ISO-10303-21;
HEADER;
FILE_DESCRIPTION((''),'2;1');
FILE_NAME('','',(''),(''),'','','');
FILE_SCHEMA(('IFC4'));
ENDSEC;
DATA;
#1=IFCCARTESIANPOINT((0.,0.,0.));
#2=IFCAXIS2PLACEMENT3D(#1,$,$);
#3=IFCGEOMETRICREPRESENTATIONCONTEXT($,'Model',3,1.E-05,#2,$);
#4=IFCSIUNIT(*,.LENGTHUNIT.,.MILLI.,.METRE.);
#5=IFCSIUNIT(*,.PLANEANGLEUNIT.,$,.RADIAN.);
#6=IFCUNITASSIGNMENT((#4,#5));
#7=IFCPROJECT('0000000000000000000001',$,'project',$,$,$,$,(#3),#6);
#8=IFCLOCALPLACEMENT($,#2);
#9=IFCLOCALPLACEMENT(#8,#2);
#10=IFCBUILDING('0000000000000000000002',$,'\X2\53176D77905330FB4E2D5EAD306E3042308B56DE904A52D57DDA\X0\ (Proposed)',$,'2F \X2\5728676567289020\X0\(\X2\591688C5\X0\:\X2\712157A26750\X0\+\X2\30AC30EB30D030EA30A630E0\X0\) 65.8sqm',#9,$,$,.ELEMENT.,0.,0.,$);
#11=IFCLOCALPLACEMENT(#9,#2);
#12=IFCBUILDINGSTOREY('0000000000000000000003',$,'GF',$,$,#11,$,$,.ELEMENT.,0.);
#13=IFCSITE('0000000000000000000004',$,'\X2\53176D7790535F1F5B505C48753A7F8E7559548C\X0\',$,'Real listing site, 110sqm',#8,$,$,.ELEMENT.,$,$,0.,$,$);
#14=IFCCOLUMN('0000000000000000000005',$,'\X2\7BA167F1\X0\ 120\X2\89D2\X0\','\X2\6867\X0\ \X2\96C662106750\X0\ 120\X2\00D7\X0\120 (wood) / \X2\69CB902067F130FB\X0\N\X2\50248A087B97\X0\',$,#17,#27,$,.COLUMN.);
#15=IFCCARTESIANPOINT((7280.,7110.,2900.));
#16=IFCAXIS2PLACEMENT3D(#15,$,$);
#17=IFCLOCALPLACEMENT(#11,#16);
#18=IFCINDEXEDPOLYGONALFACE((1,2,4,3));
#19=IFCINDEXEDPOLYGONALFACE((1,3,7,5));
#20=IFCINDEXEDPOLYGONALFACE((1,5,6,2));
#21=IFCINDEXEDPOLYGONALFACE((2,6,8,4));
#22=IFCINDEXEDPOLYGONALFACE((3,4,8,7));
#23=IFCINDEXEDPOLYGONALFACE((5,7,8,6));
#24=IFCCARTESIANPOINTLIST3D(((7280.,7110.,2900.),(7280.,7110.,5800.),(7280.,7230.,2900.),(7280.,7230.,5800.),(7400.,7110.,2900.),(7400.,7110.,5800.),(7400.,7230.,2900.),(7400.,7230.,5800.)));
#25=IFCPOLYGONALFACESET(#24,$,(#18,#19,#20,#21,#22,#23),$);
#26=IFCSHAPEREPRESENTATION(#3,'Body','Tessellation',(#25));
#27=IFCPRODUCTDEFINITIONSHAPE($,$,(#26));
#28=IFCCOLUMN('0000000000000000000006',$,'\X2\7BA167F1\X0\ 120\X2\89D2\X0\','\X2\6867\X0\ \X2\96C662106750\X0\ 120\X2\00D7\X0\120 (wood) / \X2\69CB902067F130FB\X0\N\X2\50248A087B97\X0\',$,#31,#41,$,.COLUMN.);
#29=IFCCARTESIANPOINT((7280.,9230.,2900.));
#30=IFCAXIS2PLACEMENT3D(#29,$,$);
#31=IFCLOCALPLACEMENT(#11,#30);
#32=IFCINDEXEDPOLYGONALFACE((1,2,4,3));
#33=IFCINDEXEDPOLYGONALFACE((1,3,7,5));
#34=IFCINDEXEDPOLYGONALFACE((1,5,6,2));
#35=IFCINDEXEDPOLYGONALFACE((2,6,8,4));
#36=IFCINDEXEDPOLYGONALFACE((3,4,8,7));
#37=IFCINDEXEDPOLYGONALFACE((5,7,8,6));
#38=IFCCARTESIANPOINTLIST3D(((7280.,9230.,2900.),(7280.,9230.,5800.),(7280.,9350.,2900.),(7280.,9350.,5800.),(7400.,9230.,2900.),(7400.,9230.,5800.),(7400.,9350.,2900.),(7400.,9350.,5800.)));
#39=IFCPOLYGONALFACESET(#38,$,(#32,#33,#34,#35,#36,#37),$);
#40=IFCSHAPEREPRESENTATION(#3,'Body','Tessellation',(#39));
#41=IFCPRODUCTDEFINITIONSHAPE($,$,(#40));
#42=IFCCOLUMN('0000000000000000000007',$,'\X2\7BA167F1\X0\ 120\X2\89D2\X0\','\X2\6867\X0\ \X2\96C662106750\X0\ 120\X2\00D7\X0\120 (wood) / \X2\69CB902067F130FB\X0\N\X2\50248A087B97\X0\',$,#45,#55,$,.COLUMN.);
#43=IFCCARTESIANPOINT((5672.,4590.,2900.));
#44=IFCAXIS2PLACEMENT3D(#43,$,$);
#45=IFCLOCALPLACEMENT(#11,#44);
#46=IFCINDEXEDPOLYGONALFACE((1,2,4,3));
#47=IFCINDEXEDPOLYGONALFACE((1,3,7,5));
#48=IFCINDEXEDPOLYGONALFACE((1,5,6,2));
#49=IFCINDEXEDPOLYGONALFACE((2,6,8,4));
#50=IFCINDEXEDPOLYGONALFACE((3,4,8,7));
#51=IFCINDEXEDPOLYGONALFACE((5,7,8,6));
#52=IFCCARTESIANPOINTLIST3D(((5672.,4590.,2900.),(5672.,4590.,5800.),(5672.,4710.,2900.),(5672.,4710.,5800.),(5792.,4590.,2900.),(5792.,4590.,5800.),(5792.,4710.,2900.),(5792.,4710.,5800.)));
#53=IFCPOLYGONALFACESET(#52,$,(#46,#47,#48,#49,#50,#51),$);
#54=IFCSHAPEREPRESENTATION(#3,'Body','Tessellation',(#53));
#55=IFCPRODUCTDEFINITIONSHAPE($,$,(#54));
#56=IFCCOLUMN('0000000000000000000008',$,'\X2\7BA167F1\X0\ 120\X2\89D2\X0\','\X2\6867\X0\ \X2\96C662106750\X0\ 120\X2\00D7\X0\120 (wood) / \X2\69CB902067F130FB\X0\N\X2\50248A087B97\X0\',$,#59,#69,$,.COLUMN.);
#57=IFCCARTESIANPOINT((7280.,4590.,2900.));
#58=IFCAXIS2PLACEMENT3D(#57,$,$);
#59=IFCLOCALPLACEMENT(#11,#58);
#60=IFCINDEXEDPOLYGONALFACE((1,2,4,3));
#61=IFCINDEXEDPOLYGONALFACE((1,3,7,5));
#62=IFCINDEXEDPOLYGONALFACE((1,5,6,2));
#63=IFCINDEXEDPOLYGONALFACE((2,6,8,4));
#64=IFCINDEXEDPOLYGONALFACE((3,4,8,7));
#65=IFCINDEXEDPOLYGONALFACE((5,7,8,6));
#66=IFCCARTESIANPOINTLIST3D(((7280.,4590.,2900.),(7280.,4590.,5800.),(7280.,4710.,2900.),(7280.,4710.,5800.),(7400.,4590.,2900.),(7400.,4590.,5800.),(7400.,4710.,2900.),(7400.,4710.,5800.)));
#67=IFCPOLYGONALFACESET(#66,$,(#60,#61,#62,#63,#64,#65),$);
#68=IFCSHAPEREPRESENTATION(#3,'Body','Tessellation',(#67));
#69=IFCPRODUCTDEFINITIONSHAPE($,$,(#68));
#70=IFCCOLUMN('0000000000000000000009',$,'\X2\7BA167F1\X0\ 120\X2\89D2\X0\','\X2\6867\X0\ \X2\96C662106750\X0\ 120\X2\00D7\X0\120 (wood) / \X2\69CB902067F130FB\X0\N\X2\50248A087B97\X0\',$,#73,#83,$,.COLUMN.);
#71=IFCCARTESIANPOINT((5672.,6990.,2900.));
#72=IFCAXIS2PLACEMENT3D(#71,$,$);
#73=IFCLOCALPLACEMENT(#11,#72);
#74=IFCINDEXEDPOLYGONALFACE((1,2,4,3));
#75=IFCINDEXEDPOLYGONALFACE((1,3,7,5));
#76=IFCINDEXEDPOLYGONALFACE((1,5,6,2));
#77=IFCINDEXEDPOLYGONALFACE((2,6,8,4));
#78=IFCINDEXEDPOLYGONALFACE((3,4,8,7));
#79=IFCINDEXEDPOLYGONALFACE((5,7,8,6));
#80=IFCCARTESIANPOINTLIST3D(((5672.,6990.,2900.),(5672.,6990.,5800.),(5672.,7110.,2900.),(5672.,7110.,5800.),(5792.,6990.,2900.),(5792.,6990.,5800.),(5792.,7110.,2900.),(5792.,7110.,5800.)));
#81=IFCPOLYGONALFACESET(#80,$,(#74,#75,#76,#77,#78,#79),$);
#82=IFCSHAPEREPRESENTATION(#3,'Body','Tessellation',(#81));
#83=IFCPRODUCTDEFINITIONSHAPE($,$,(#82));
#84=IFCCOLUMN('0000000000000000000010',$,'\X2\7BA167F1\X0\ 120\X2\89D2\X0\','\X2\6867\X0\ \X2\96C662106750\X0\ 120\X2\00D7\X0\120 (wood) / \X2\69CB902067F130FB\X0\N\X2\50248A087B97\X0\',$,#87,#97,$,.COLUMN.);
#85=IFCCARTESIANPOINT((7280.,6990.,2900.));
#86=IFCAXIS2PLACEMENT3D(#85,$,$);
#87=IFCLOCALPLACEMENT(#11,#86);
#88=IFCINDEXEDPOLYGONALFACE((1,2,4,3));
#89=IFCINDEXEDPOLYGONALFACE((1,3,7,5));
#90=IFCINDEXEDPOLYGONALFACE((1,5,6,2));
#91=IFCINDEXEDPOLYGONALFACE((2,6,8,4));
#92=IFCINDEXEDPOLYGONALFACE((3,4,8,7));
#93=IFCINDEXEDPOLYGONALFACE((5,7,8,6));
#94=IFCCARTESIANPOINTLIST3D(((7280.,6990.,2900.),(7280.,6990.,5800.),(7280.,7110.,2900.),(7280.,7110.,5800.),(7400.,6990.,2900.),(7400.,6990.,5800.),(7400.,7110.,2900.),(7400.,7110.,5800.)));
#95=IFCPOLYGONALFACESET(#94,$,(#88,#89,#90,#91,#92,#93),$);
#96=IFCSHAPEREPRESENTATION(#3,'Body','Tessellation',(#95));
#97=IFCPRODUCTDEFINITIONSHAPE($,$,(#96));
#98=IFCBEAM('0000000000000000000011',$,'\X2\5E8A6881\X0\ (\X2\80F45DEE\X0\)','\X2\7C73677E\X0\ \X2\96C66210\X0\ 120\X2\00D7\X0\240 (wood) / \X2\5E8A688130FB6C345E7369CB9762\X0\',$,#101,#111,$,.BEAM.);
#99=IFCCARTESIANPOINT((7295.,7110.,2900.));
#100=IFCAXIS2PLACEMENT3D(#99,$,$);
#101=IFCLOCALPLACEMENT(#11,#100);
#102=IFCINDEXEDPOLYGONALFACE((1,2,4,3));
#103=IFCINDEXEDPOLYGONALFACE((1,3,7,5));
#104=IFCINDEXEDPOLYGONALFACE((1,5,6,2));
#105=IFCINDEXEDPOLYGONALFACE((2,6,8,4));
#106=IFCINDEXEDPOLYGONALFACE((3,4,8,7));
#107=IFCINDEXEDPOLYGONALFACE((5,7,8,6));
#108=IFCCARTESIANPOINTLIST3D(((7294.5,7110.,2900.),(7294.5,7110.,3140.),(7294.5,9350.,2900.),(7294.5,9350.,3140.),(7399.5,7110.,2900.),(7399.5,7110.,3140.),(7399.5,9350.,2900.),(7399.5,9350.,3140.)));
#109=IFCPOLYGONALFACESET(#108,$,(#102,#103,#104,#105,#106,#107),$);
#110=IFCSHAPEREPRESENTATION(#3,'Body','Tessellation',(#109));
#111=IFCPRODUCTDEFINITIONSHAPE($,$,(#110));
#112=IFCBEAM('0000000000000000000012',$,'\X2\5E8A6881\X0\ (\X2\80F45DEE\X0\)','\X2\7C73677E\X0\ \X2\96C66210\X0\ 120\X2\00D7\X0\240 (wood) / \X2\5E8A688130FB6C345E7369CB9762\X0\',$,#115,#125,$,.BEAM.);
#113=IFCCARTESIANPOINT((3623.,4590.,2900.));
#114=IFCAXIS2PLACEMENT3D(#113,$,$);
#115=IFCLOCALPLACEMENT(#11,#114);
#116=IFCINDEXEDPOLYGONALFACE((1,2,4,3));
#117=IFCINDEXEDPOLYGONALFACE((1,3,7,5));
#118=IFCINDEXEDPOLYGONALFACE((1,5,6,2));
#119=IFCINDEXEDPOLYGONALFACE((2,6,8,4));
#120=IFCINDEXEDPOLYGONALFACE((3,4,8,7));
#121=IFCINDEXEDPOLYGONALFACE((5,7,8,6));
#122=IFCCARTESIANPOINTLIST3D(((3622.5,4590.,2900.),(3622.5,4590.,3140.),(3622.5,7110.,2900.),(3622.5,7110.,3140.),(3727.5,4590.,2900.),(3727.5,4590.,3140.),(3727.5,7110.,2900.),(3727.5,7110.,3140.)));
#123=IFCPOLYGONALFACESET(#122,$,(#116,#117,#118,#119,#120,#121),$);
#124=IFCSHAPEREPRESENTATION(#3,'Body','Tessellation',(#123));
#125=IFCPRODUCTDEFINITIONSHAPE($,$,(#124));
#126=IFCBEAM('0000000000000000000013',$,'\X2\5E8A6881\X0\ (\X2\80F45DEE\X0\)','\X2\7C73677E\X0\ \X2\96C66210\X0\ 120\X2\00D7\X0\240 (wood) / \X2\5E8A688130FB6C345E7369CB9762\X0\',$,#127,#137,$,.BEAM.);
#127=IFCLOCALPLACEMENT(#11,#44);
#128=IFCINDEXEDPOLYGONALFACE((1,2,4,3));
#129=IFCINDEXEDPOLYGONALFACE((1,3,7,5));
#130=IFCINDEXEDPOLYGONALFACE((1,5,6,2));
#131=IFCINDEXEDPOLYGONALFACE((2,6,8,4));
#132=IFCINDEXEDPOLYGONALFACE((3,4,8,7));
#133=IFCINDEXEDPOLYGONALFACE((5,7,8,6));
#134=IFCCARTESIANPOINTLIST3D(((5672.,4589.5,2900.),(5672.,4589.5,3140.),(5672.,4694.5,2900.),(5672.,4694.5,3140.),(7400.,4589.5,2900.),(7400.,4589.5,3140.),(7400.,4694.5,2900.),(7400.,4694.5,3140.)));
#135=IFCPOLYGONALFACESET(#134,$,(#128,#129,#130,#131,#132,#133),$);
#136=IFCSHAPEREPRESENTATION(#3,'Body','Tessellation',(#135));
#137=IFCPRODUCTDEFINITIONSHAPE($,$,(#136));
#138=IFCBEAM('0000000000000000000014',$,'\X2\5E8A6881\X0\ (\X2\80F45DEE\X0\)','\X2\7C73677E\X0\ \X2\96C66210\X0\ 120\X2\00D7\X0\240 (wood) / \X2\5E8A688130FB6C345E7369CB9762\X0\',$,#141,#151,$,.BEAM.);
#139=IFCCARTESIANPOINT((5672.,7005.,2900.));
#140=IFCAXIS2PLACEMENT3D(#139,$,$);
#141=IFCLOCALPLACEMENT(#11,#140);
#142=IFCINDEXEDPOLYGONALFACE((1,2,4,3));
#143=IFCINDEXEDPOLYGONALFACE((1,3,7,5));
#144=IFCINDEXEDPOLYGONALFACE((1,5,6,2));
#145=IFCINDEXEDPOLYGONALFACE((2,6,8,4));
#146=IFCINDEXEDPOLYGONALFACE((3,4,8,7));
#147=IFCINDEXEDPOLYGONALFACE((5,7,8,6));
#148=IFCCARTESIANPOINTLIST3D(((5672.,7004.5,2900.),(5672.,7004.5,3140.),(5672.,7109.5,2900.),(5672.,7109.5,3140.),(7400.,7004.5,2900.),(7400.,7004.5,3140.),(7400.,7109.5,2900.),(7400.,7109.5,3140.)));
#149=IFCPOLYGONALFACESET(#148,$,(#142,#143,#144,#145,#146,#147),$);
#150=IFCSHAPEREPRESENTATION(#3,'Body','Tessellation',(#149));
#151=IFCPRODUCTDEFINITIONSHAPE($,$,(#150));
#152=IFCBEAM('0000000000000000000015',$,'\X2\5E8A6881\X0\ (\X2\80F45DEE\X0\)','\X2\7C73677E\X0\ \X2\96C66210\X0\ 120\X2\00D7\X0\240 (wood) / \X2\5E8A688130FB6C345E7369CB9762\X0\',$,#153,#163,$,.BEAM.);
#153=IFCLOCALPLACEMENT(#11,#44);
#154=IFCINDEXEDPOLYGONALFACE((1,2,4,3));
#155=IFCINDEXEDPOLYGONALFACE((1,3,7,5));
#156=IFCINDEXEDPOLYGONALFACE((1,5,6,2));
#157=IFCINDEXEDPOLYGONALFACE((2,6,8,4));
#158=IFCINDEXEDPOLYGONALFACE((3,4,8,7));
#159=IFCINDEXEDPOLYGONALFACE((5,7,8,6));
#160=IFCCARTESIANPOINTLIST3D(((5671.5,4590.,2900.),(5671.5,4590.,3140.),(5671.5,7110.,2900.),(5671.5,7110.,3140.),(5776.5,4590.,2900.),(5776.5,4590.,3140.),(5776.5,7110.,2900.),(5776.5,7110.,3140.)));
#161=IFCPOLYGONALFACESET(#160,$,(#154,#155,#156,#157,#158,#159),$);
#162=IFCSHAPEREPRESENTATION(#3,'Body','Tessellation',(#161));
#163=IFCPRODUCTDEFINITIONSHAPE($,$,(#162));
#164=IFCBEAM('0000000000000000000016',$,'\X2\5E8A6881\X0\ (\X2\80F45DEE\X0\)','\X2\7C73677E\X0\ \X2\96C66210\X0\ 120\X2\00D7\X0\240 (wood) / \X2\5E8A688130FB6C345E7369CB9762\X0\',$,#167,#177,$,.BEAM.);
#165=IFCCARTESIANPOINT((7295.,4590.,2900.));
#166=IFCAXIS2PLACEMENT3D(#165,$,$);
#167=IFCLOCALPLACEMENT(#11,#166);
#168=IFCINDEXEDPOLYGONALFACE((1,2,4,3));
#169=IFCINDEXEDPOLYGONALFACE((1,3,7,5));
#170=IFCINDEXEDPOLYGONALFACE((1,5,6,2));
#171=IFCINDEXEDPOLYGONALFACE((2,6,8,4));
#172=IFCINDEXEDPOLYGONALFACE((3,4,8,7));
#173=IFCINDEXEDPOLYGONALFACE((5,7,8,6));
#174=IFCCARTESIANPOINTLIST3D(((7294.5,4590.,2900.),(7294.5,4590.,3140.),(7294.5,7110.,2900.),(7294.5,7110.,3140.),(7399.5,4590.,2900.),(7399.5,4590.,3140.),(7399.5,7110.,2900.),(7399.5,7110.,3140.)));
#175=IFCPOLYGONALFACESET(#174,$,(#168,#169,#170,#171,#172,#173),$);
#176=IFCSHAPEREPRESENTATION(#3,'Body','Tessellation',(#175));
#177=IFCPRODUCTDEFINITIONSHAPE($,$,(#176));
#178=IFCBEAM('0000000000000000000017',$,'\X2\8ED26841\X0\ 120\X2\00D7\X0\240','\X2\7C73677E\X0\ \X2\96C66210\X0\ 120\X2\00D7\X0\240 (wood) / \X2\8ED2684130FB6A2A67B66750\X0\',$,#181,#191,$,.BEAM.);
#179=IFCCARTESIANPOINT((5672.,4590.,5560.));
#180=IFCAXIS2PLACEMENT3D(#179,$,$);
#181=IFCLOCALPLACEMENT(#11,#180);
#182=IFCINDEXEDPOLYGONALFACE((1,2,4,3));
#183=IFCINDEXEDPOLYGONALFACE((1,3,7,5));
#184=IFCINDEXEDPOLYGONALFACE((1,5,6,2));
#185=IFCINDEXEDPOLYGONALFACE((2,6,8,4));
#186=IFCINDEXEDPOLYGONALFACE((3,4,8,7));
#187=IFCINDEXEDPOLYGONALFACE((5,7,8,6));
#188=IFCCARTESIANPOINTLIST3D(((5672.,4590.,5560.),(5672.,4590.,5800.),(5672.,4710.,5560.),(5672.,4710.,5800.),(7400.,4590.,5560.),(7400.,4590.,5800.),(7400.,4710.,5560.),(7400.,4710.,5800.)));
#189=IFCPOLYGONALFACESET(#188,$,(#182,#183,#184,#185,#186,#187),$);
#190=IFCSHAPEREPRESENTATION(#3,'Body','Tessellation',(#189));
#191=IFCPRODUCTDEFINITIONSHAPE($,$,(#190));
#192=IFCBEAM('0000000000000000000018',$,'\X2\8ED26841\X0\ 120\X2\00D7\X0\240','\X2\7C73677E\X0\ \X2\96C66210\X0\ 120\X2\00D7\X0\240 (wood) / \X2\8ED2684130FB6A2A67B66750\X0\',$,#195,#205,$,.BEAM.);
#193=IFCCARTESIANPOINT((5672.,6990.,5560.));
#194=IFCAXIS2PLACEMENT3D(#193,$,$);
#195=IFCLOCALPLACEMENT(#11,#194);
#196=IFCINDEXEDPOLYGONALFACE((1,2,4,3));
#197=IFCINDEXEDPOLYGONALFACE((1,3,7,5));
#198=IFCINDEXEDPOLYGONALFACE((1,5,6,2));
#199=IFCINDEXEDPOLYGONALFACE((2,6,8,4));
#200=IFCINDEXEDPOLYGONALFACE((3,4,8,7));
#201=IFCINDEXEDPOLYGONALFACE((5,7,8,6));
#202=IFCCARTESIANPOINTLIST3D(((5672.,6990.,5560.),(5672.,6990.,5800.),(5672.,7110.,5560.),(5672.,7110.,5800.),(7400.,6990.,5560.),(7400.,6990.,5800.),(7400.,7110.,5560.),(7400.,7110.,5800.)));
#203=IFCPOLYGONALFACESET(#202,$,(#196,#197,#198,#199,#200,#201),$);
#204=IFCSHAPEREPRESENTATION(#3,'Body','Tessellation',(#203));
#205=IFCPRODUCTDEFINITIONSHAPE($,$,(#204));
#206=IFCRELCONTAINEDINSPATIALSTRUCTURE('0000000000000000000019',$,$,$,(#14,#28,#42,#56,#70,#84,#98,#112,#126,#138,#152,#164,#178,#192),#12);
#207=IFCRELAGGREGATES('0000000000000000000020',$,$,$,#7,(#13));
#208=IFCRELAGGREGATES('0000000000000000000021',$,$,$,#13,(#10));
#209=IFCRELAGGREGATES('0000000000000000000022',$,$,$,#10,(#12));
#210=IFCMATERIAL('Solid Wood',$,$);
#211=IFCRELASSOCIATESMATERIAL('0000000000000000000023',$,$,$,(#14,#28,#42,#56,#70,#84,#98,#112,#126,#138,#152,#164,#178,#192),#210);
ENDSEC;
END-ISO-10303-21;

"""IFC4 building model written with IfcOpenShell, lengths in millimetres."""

from ifc_helpers import new_model, si_unit, frame, frame_2d, origin, place, context, project, spatial, rectangle, extrude, material, element, save


model = new_model("IFC4")

# Units and contexts
model_context = context("Model", 3, precision=1e-05, world=origin())
ifc_project = project(units=[si_unit("LENGTHUNIT", "METRE", prefix="MILLI"), si_unit("PLANEANGLEUNIT", "RADIAN")], contexts=[model_context])

# Site, building, storey
site_placement = place(None, origin())
site = spatial("IfcSite", under=ifc_project, at=site_placement, Name="北海道弟子屈町美留和", ObjectType="Real listing site, 110sqm", CompositionType="ELEMENT", RefElevation=0.0)
building_placement = place(site_placement, origin())
building = spatial("IfcBuilding", under=site, at=building_placement, Name="北海道・中庭のある回遊動線 (Proposed)", ObjectType="2F 在来木造(外装:無垢材+ガルバリウム) 65.8sqm", CompositionType="ELEMENT", ElevationOfRefHeight=0.0, ElevationOfTerrain=0.0)
storey_placement = place(building_placement, origin())
storey = spatial("IfcBuildingStorey", under=building, at=storey_placement, Name="GF", CompositionType="ELEMENT", Elevation=0.0)

# Columns
ifc_material_1 = material(Name="Solid Wood")
column_1_placement = place(storey_placement, frame((7280.0, 7110.0, 2900.0)))
element("IfcColumn", 1, at=column_1_placement, inside=storey, material=ifc_material_1, Name="管柱 120角", Description="桧 集成材 120×120 (wood) / 構造柱・N値計算", PredefinedType="COLUMN", context=model_context, shape_type="SweptSolid", body=[
    extrude(rectangle(XDim=120.0, YDim=120.0, at=frame_2d((60.0, 60.0))), frame((7280.0, 7110.0, 2900.0)), (0.0, 0.0, 1.0), 2900.0),
])
column_2_placement = place(storey_placement, frame((7280.0, 9230.0, 2900.0)))
element("IfcColumn", 2, at=column_2_placement, inside=storey, material=ifc_material_1, Name="管柱 120角", Description="桧 集成材 120×120 (wood) / 構造柱・N値計算", PredefinedType="COLUMN", context=model_context, shape_type="SweptSolid", body=[
    extrude(rectangle(XDim=120.0, YDim=120.0, at=frame_2d((60.0, 60.0))), frame((7280.0, 9230.0, 2900.0)), (0.0, 0.0, 1.0), 2900.0),
])
column_3_placement = place(storey_placement, frame((5672.0, 4590.0, 2900.0)))
element("IfcColumn", 3, at=column_3_placement, inside=storey, material=ifc_material_1, Name="管柱 120角", Description="桧 集成材 120×120 (wood) / 構造柱・N値計算", PredefinedType="COLUMN", context=model_context, shape_type="SweptSolid", body=[
    extrude(rectangle(XDim=120.0, YDim=120.0, at=frame_2d((60.0, 60.0))), frame((5672.0, 4590.0, 2900.0)), (0.0, 0.0, 1.0), 2900.0),
])
column_4_placement = place(storey_placement, frame((7280.0, 4590.0, 2900.0)))
element("IfcColumn", 4, at=column_4_placement, inside=storey, material=ifc_material_1, Name="管柱 120角", Description="桧 集成材 120×120 (wood) / 構造柱・N値計算", PredefinedType="COLUMN", context=model_context, shape_type="SweptSolid", body=[
    extrude(rectangle(XDim=120.0, YDim=120.0, at=frame_2d((60.0, 60.0))), frame((7280.0, 4590.0, 2900.0)), (0.0, 0.0, 1.0), 2900.0),
])
column_5_placement = place(storey_placement, frame((5672.0, 6990.0, 2900.0)))
element("IfcColumn", 5, at=column_5_placement, inside=storey, material=ifc_material_1, Name="管柱 120角", Description="桧 集成材 120×120 (wood) / 構造柱・N値計算", PredefinedType="COLUMN", context=model_context, shape_type="SweptSolid", body=[
    extrude(rectangle(XDim=120.0, YDim=120.0, at=frame_2d((60.0, 60.0))), frame((5672.0, 6990.0, 2900.0)), (0.0, 0.0, 1.0), 2900.0),
])
column_6_placement = place(storey_placement, frame((7280.0, 6990.0, 2900.0)))
element("IfcColumn", 6, at=column_6_placement, inside=storey, material=ifc_material_1, Name="管柱 120角", Description="桧 集成材 120×120 (wood) / 構造柱・N値計算", PredefinedType="COLUMN", context=model_context, shape_type="SweptSolid", body=[
    extrude(rectangle(XDim=120.0, YDim=120.0, at=frame_2d((60.0, 60.0))), frame((7280.0, 6990.0, 2900.0)), (0.0, 0.0, 1.0), 2900.0),
])

# Beams
beam_1_placement = place(storey_placement, frame((7295.0, 7110.0, 2900.0)))
element("IfcBeam", 7, at=beam_1_placement, inside=storey, material=ifc_material_1, Name="床梁 (胴差)", Description="米松 集成 120×240 (wood) / 床梁・水平構面", PredefinedType="BEAM", context=model_context, shape_type="SweptSolid", body=[
    extrude(rectangle(XDim=105.0, YDim=2240.0, at=frame_2d((52.0, 1120.0))), frame((7295.0, 7110.0, 2900.0)), (0.0, 0.0, 1.0), 240.0),
])
beam_2_placement = place(storey_placement, frame((3623.0, 4590.0, 2900.0)))
element("IfcBeam", 8, at=beam_2_placement, inside=storey, material=ifc_material_1, Name="床梁 (胴差)", Description="米松 集成 120×240 (wood) / 床梁・水平構面", PredefinedType="BEAM", context=model_context, shape_type="SweptSolid", body=[
    extrude(rectangle(XDim=105.0, YDim=2520.0, at=frame_2d((52.0, 1260.0))), frame((3623.0, 4590.0, 2900.0)), (0.0, 0.0, 1.0), 240.0),
])
beam_3_placement = place(storey_placement, frame((5672.0, 4590.0, 2900.0)))
element("IfcBeam", 9, at=beam_3_placement, inside=storey, material=ifc_material_1, Name="床梁 (胴差)", Description="米松 集成 120×240 (wood) / 床梁・水平構面", PredefinedType="BEAM", context=model_context, shape_type="SweptSolid", body=[
    extrude(rectangle(XDim=1728.0, YDim=105.0, at=frame_2d((864.0, 52.0))), frame((5672.0, 4590.0, 2900.0)), (0.0, 0.0, 1.0), 240.0),
])
beam_4_placement = place(storey_placement, frame((5672.0, 7005.0, 2900.0)))
element("IfcBeam", 10, at=beam_4_placement, inside=storey, material=ifc_material_1, Name="床梁 (胴差)", Description="米松 集成 120×240 (wood) / 床梁・水平構面", PredefinedType="BEAM", context=model_context, shape_type="SweptSolid", body=[
    extrude(rectangle(XDim=1728.0, YDim=105.0, at=frame_2d((864.0, 52.0))), frame((5672.0, 7005.0, 2900.0)), (0.0, 0.0, 1.0), 240.0),
])
beam_5_placement = place(storey_placement, frame((5672.0, 4590.0, 2900.0)))
element("IfcBeam", 11, at=beam_5_placement, inside=storey, material=ifc_material_1, Name="床梁 (胴差)", Description="米松 集成 120×240 (wood) / 床梁・水平構面", PredefinedType="BEAM", context=model_context, shape_type="SweptSolid", body=[
    extrude(rectangle(XDim=105.0, YDim=2520.0, at=frame_2d((52.0, 1260.0))), frame((5672.0, 4590.0, 2900.0)), (0.0, 0.0, 1.0), 240.0),
])
beam_6_placement = place(storey_placement, frame((7295.0, 4590.0, 2900.0)))
element("IfcBeam", 12, at=beam_6_placement, inside=storey, material=ifc_material_1, Name="床梁 (胴差)", Description="米松 集成 120×240 (wood) / 床梁・水平構面", PredefinedType="BEAM", context=model_context, shape_type="SweptSolid", body=[
    extrude(rectangle(XDim=105.0, YDim=2520.0, at=frame_2d((52.0, 1260.0))), frame((7295.0, 4590.0, 2900.0)), (0.0, 0.0, 1.0), 240.0),
])
beam_7_placement = place(storey_placement, frame((5672.0, 4590.0, 5560.0)))
element("IfcBeam", 13, at=beam_7_placement, inside=storey, material=ifc_material_1, Name="軒桁 120×240", Description="米松 集成 120×240 (wood) / 軒桁・横架材", PredefinedType="BEAM", context=model_context, shape_type="SweptSolid", body=[
    extrude(rectangle(XDim=1728.0, YDim=120.0, at=frame_2d((864.0, 60.0))), frame((5672.0, 4590.0, 5560.0)), (0.0, 0.0, 1.0), 240.0),
])
beam_8_placement = place(storey_placement, frame((5672.0, 6990.0, 5560.0)))
element("IfcBeam", 14, at=beam_8_placement, inside=storey, material=ifc_material_1, Name="軒桁 120×240", Description="米松 集成 120×240 (wood) / 軒桁・横架材", PredefinedType="BEAM", context=model_context, shape_type="SweptSolid", body=[
    extrude(rectangle(XDim=1728.0, YDim=120.0, at=frame_2d((864.0, 60.0))), frame((5672.0, 6990.0, 5560.0)), (0.0, 0.0, 1.0), 240.0),
])

save(model, "model.ifc")
